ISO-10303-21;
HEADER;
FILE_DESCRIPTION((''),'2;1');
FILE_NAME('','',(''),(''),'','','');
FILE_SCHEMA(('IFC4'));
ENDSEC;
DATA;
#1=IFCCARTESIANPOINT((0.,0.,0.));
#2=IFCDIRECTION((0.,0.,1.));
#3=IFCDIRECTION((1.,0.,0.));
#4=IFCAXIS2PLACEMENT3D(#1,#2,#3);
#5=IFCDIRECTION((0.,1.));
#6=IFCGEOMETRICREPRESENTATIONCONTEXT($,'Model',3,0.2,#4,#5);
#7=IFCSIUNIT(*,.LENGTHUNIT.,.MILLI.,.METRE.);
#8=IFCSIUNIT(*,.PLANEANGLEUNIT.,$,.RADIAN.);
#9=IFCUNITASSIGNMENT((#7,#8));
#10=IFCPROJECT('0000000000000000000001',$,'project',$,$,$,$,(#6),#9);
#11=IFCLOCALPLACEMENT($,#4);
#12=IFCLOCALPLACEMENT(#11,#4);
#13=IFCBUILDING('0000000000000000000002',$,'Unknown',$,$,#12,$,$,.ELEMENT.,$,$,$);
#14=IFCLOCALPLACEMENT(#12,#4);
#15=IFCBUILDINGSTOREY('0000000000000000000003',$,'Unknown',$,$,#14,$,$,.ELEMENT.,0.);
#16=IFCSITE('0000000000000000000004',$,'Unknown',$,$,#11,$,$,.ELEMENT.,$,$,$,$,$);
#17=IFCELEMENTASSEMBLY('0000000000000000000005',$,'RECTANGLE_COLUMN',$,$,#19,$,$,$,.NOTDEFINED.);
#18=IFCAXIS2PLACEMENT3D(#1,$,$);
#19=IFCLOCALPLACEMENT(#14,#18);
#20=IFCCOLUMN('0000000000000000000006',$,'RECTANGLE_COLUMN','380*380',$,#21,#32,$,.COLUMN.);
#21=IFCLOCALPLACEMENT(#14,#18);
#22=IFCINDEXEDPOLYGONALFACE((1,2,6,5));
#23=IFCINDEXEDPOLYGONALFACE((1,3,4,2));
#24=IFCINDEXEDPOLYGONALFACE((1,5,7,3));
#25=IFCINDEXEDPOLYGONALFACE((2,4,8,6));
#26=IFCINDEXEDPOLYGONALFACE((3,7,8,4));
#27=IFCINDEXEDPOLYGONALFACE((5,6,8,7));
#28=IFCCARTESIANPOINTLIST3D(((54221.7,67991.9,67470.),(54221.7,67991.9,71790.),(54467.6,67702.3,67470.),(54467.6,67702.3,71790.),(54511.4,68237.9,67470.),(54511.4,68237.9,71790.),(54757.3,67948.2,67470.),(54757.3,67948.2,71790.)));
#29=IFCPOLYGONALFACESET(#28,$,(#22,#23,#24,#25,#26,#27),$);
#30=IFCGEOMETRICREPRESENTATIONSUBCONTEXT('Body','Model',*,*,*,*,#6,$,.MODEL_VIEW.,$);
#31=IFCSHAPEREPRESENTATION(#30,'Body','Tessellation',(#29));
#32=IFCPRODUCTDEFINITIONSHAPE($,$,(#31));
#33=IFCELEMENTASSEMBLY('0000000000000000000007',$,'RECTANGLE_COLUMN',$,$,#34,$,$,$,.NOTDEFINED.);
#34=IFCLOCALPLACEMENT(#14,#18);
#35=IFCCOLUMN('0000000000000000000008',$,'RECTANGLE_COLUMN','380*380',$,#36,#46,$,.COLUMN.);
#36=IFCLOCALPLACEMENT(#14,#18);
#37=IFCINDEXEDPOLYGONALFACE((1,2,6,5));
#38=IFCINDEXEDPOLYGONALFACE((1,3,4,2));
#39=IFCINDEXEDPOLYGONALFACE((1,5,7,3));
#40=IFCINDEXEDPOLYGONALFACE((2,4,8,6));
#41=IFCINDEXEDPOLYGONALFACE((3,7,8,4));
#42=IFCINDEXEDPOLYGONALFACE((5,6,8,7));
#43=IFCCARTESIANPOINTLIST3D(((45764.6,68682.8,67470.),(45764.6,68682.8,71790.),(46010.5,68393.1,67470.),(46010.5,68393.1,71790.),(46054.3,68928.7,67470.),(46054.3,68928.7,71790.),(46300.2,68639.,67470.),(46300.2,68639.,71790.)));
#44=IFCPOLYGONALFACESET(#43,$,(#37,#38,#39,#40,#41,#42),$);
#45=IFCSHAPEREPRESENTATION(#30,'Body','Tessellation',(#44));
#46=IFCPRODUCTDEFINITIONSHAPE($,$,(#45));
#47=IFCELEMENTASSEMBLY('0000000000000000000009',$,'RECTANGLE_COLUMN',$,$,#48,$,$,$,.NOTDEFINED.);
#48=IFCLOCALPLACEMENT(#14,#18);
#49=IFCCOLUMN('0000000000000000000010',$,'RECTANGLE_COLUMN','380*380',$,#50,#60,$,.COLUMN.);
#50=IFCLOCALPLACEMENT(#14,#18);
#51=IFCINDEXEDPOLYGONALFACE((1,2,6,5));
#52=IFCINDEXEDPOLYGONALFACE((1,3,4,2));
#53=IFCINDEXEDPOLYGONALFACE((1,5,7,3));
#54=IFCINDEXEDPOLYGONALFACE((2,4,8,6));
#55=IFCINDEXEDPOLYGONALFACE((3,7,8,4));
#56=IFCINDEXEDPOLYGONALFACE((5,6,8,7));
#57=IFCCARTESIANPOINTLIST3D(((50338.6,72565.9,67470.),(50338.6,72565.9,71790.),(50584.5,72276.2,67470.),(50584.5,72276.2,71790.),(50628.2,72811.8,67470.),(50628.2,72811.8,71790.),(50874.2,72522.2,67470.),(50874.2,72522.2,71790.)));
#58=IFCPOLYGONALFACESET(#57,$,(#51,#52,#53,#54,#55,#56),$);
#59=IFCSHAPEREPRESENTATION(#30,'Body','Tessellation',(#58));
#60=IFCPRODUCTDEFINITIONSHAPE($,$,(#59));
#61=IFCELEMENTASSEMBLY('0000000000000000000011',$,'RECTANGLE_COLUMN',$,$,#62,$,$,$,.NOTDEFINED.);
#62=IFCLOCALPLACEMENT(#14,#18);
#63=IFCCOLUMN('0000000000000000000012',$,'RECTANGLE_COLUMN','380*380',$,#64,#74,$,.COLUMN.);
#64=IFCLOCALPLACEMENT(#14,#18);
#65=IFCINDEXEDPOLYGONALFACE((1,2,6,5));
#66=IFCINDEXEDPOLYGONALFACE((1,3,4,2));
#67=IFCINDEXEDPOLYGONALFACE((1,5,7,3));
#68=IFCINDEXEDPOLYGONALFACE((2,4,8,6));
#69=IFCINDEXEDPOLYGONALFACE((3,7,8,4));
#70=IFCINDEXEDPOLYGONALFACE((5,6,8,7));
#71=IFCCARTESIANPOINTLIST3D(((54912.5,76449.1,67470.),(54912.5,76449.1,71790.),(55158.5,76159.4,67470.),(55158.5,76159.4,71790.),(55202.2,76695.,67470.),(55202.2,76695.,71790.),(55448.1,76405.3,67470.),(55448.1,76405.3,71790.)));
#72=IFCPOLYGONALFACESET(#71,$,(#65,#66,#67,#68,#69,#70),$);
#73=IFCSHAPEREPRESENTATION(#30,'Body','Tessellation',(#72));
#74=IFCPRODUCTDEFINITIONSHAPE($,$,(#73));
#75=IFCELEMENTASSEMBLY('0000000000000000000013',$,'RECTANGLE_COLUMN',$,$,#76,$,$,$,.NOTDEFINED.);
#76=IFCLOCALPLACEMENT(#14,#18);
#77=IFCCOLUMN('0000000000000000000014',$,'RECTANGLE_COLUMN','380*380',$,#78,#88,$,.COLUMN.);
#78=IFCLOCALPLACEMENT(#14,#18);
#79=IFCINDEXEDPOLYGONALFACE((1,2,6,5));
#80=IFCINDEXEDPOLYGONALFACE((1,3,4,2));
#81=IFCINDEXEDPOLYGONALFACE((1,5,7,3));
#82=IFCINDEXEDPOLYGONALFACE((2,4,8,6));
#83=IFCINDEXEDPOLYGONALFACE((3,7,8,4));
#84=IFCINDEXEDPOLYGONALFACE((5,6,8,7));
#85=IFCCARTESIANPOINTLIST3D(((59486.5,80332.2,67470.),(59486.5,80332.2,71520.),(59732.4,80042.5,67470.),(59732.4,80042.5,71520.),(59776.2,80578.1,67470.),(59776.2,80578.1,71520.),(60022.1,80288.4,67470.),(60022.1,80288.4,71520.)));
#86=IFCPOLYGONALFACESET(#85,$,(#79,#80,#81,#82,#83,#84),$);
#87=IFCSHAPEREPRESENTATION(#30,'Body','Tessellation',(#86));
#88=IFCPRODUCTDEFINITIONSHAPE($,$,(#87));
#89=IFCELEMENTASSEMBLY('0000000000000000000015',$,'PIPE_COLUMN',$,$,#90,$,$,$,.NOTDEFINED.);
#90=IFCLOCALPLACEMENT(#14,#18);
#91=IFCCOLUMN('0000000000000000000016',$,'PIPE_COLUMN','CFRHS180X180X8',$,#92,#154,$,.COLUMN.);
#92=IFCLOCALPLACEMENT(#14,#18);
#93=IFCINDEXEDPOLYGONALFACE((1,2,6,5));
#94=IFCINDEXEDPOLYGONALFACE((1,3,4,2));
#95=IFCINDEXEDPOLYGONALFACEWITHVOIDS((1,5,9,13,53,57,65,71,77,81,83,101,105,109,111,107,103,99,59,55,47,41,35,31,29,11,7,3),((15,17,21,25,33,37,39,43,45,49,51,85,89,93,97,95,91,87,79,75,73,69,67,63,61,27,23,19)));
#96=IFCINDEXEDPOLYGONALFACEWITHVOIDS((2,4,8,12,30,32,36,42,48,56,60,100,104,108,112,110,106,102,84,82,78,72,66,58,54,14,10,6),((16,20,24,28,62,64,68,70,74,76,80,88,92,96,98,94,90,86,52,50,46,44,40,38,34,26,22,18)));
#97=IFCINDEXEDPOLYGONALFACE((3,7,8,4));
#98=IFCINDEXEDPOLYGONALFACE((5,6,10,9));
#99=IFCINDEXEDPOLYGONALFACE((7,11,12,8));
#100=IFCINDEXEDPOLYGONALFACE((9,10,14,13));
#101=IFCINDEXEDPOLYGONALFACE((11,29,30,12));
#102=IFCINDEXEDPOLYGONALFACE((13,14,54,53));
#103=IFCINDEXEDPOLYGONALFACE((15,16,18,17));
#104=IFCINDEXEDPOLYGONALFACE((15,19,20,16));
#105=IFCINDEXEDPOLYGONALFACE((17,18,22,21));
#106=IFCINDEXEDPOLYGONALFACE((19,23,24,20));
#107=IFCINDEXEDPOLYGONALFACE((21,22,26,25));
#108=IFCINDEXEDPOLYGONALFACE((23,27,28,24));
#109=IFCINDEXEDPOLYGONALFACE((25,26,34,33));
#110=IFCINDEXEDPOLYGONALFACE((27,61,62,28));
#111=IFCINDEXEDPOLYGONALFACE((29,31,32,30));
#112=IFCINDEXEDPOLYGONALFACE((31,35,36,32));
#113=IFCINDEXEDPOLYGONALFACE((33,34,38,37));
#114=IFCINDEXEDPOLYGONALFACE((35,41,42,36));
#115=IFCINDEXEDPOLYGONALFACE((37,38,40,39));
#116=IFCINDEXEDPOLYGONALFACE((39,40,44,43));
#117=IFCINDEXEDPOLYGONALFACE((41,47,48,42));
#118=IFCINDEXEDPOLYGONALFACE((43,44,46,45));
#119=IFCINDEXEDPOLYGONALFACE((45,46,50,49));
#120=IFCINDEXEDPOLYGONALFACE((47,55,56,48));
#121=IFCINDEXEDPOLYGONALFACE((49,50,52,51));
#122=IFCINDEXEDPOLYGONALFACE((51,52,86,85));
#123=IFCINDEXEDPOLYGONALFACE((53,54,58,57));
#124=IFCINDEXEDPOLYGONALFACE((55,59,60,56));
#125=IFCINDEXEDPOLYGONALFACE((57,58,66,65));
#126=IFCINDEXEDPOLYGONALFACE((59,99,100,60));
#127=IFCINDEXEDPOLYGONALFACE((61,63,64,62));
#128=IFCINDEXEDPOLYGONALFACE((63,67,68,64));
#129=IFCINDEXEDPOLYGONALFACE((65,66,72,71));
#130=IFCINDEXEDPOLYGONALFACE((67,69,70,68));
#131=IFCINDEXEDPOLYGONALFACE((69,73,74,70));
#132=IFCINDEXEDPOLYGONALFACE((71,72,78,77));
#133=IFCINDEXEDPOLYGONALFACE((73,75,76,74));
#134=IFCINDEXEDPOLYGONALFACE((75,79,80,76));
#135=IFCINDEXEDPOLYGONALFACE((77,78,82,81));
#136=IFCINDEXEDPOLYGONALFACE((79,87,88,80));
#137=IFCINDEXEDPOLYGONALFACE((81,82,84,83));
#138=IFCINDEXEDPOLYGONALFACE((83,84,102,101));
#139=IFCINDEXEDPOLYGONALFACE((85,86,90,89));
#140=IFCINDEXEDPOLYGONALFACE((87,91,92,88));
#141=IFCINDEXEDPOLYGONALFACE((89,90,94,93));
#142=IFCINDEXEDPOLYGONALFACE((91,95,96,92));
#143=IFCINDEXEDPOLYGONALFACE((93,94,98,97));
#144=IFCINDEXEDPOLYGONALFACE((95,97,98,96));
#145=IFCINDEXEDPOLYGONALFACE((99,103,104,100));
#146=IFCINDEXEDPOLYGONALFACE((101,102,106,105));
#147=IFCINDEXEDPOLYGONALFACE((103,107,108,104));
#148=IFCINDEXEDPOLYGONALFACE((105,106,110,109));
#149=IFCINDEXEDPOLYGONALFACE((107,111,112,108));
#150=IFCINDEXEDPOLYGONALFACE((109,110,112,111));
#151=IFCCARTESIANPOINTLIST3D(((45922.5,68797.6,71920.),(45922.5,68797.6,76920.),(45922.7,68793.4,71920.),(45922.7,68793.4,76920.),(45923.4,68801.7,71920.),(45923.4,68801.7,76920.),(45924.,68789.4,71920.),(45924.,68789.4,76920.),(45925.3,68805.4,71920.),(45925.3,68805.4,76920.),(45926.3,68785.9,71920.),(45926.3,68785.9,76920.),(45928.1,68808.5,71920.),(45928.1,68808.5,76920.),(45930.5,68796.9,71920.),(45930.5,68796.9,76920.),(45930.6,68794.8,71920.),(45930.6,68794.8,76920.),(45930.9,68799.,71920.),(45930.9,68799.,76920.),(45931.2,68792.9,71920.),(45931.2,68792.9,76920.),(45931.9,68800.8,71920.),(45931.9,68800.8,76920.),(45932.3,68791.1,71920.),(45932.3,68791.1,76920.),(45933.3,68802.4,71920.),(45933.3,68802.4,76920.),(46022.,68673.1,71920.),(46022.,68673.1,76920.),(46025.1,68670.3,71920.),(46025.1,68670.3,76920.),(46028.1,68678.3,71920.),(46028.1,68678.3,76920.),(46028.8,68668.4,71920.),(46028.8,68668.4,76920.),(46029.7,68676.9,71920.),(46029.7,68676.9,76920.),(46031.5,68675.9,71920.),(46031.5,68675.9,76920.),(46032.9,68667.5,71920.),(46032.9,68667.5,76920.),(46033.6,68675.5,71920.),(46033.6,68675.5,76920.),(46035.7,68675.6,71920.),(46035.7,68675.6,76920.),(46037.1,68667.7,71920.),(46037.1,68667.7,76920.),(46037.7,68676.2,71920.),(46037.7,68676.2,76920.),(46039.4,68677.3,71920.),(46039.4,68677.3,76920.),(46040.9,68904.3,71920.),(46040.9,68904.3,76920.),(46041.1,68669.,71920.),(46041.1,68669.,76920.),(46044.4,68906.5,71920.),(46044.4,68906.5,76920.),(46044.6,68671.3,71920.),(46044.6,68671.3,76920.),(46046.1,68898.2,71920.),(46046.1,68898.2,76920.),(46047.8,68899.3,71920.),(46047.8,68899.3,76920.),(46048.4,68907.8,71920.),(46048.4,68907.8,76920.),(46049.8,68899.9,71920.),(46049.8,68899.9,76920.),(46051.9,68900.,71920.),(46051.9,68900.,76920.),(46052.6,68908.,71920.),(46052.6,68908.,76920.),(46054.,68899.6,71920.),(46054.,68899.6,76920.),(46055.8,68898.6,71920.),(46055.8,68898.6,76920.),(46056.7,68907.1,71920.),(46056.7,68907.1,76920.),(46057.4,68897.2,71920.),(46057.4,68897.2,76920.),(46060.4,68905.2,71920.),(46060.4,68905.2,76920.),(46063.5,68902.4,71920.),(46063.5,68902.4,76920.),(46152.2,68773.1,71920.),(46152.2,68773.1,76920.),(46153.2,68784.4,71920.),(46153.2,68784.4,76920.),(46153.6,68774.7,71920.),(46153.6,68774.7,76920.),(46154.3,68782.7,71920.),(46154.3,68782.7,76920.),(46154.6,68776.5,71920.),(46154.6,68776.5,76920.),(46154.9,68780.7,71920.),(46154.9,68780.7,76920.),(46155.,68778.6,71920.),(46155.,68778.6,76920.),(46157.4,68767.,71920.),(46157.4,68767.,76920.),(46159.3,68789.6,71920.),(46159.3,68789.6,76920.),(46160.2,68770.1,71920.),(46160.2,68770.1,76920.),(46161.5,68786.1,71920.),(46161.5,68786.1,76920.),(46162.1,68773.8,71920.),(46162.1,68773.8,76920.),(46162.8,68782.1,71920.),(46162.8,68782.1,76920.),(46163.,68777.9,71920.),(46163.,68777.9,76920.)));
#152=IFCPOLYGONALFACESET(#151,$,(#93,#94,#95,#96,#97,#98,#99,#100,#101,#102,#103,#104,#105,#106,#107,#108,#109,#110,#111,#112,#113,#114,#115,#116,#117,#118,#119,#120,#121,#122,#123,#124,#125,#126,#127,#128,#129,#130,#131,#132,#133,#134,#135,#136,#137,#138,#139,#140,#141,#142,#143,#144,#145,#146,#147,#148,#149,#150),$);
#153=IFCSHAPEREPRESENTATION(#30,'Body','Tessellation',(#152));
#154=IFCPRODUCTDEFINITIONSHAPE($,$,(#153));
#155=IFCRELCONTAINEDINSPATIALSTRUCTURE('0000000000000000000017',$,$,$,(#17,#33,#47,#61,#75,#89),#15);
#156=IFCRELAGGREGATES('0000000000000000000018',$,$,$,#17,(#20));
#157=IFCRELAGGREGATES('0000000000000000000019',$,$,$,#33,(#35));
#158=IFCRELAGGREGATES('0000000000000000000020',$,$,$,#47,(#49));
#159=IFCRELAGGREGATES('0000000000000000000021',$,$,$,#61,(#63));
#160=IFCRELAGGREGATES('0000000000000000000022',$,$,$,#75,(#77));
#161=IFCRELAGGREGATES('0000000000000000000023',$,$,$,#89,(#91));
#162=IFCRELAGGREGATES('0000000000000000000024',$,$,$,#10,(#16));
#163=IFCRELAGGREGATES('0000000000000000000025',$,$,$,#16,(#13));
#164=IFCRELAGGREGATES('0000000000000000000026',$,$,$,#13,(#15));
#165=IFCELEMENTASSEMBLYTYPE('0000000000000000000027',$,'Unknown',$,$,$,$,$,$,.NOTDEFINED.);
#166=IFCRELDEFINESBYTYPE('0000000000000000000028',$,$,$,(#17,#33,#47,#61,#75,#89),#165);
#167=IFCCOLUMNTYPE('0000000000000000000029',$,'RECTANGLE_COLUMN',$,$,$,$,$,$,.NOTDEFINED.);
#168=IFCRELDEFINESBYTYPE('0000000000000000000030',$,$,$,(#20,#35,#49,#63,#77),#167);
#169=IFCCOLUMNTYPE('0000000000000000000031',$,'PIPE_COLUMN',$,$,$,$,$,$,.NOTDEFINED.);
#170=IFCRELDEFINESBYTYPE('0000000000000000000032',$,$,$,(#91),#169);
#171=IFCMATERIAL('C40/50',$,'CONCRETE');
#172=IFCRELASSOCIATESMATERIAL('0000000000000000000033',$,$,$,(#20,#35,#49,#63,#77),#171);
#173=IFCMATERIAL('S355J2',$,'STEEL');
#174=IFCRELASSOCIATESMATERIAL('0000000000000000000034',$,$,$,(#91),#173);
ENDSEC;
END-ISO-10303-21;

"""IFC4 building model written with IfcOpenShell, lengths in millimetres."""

from ifc_helpers import new_model, si_unit, direction, frame, origin_with_axes, origin_2d_with_axis, place, context, subcontext, project, spatial, rectangle, hollow_rectangle, extrude, material, material_profile, profile_set, profile_usage, type_object, element, aggregate, save


model = new_model("IFC4")

# Units and contexts
model_context = context("Model", 3, precision=0.2, world=origin_with_axes(), true_north=direction((0.0, 1.0)))
body_context = subcontext(model_context, "Body", "Model", "MODEL_VIEW")
ifc_project = project(units=[si_unit("LENGTHUNIT", "METRE", prefix="MILLI"), si_unit("PLANEANGLEUNIT", "RADIAN")], contexts=[model_context])

# Site, building, storey
site_placement = place(None, origin_with_axes())
site = spatial("IfcSite", under=ifc_project, at=site_placement, Name="Unknown", CompositionType="ELEMENT")
building_placement = place(site_placement, origin_with_axes())
building = spatial("IfcBuilding", under=site, at=building_placement, Name="Unknown", CompositionType="ELEMENT")
storey_placement = place(building_placement, origin_with_axes())
storey = spatial("IfcBuildingStorey", under=building, at=storey_placement, Name="Unknown", CompositionType="ELEMENT", Elevation=0.0)

# Element assemblies, columns
element_assembly_type = type_object("IfcElementAssemblyType", Name="Unknown", PredefinedType="NOTDEFINED")
assembly_1_placement = place(storey_placement, frame((54489.5, 67970.1, 67470.0), z_axis=(-0.762329, -0.64719, 0.0), x_axis=(0.0, 0.0, 1.0)))
assembly_1 = element("IfcElementAssembly", 1, at=assembly_1_placement, inside=storey, type_object=element_assembly_type, Name="RECTANGLE_COLUMN", PredefinedType="NOTDEFINED")
ifc_material_1 = material(Name="C40/50", Category="CONCRETE")
ifc_material_profile_1 = material_profile(ifc_material_1, rectangle(XDim=380.0, YDim=380.0, at=origin_2d_with_axis()), Name="380*380")
ifc_profile_set_1 = profile_set([ifc_material_profile_1])
ifc_profile_usage_1 = profile_usage(ifc_profile_set_1, cardinal=5)
column_type_1 = type_object("IfcColumnType", Name="RECTANGLE_COLUMN")
column_1_placement = place(assembly_1_placement, origin_with_axes())
column_1 = element("IfcColumn", 2, at=column_1_placement, type_object=column_type_1, material=ifc_profile_usage_1, Name="RECTANGLE_COLUMN", Description="380*380", PredefinedType="COLUMN", context=body_context, shape_type="SolidModel", body=[
    extrude(rectangle(XDim=380.0, YDim=380.0, at=origin_2d_with_axis()), frame((0.0, 0.0, 0.0), z_axis=(-1.0, 0.0, 0.0), x_axis=(0.0, 0.0, 1.0)), (0.0, 0.0, -1.0), 4320.0),
])
aggregate(assembly_1, [column_1])
assembly_2_placement = place(storey_placement, frame((46032.4, 68660.9, 67470.0), z_axis=(-0.762329, -0.64719, 0.0), x_axis=(0.0, 0.0, 1.0)))
assembly_2 = element("IfcElementAssembly", 3, at=assembly_2_placement, inside=storey, type_object=element_assembly_type, Name="RECTANGLE_COLUMN", PredefinedType="NOTDEFINED")
column_2_placement = place(assembly_2_placement, origin_with_axes())
column_2 = element("IfcColumn", 4, at=column_2_placement, type_object=column_type_1, material=ifc_profile_usage_1, Name="RECTANGLE_COLUMN", Description="380*380", PredefinedType="COLUMN", context=body_context, shape_type="SolidModel", body=[
    extrude(rectangle(XDim=380.0, YDim=380.0, at=origin_2d_with_axis()), frame((0.0, 0.0, 0.0), z_axis=(-1.0, 0.0, 0.0), x_axis=(0.0, 0.0, 1.0)), (0.0, 0.0, -1.0), 4320.0),
])
aggregate(assembly_2, [column_2])
assembly_3_placement = place(storey_placement, frame((50606.4, 72544.0, 67470.0), z_axis=(-0.762329, -0.64719, 0.0), x_axis=(0.0, 0.0, 1.0)))
assembly_3 = element("IfcElementAssembly", 5, at=assembly_3_placement, inside=storey, type_object=element_assembly_type, Name="RECTANGLE_COLUMN", PredefinedType="NOTDEFINED")
column_3_placement = place(assembly_3_placement, origin_with_axes())
column_3 = element("IfcColumn", 6, at=column_3_placement, type_object=column_type_1, material=ifc_profile_usage_1, Name="RECTANGLE_COLUMN", Description="380*380", PredefinedType="COLUMN", context=body_context, shape_type="SolidModel", body=[
    extrude(rectangle(XDim=380.0, YDim=380.0, at=origin_2d_with_axis()), frame((0.0, 0.0, 0.0), z_axis=(-1.0, 0.0, 0.0), x_axis=(0.0, 0.0, 1.0)), (0.0, 0.0, -1.0), 4320.0),
])
aggregate(assembly_3, [column_3])
assembly_4_placement = place(storey_placement, frame((55180.3, 76427.2, 67470.0), z_axis=(-0.762329, -0.64719, 0.0), x_axis=(0.0, 0.0, 1.0)))
assembly_4 = element("IfcElementAssembly", 7, at=assembly_4_placement, inside=storey, type_object=element_assembly_type, Name="RECTANGLE_COLUMN", PredefinedType="NOTDEFINED")
column_4_placement = place(assembly_4_placement, origin_with_axes())
column_4 = element("IfcColumn", 8, at=column_4_placement, type_object=column_type_1, material=ifc_profile_usage_1, Name="RECTANGLE_COLUMN", Description="380*380", PredefinedType="COLUMN", context=body_context, shape_type="SolidModel", body=[
    extrude(rectangle(XDim=380.0, YDim=380.0, at=origin_2d_with_axis()), frame((0.0, 0.0, 0.0), z_axis=(-1.0, 0.0, 0.0), x_axis=(0.0, 0.0, 1.0)), (0.0, 0.0, -1.0), 4320.0),
])
aggregate(assembly_4, [column_4])
assembly_5_placement = place(storey_placement, frame((59754.3, 80310.3, 67470.0), z_axis=(-0.762329, -0.64719, 0.0), x_axis=(0.0, 0.0, 1.0)))
assembly_5 = element("IfcElementAssembly", 9, at=assembly_5_placement, inside=storey, type_object=element_assembly_type, Name="RECTANGLE_COLUMN", PredefinedType="NOTDEFINED")
column_5_placement = place(assembly_5_placement, origin_with_axes())
column_5 = element("IfcColumn", 10, at=column_5_placement, type_object=column_type_1, material=ifc_profile_usage_1, Name="RECTANGLE_COLUMN", Description="380*380", PredefinedType="COLUMN", context=body_context, shape_type="SolidModel", body=[
    extrude(rectangle(XDim=380.0, YDim=380.0, at=origin_2d_with_axis()), frame((0.0, 0.0, 0.0), z_axis=(-1.0, 0.0, 0.0), x_axis=(0.0, 0.0, 1.0)), (0.0, 0.0, -1.0), 4050.0),
])
aggregate(assembly_5, [column_5])
assembly_6_placement = place(storey_placement, frame((46042.8, 68787.8, 71920.0), z_axis=(-0.762329, -0.64719, 0.0), x_axis=(0.0, 0.0, 1.0)))
assembly_6 = element("IfcElementAssembly", 11, at=assembly_6_placement, inside=storey, type_object=element_assembly_type, Name="PIPE_COLUMN", PredefinedType="NOTDEFINED")
ifc_material_2 = material(Name="S355J2", Category="STEEL")
ifc_material_profile_2 = material_profile(ifc_material_2, hollow_rectangle(XDim=180.0, YDim=180.0, WallThickness=8.0, InnerFilletRadius=8.0, OuterFilletRadius=16.0, at=origin_2d_with_axis()), Name="CFRHS180X180X8")
ifc_profile_set_2 = profile_set([ifc_material_profile_2])
ifc_profile_usage_2 = profile_usage(ifc_profile_set_2, cardinal=9)
column_type_2 = type_object("IfcColumnType", Name="PIPE_COLUMN")
column_6_placement = place(assembly_6_placement, origin_with_axes())
column_6 = element("IfcColumn", 12, at=column_6_placement, type_object=column_type_2, material=ifc_profile_usage_2, Name="PIPE_COLUMN", Description="CFRHS180X180X8", PredefinedType="COLUMN", context=body_context, shape_type="SolidModel", body=[
    extrude(hollow_rectangle(XDim=180.0, YDim=180.0, WallThickness=8.0, InnerFilletRadius=8.0, OuterFilletRadius=16.0, at=origin_2d_with_axis()), frame((0.0, 0.0, 0.0), z_axis=(-1.0, 0.0, 0.0), x_axis=(0.0, 0.0, 1.0)), (0.0, 0.0, -1.0), 5000.0),
])
aggregate(assembly_6, [column_6])

save(model, "model.ifc")
